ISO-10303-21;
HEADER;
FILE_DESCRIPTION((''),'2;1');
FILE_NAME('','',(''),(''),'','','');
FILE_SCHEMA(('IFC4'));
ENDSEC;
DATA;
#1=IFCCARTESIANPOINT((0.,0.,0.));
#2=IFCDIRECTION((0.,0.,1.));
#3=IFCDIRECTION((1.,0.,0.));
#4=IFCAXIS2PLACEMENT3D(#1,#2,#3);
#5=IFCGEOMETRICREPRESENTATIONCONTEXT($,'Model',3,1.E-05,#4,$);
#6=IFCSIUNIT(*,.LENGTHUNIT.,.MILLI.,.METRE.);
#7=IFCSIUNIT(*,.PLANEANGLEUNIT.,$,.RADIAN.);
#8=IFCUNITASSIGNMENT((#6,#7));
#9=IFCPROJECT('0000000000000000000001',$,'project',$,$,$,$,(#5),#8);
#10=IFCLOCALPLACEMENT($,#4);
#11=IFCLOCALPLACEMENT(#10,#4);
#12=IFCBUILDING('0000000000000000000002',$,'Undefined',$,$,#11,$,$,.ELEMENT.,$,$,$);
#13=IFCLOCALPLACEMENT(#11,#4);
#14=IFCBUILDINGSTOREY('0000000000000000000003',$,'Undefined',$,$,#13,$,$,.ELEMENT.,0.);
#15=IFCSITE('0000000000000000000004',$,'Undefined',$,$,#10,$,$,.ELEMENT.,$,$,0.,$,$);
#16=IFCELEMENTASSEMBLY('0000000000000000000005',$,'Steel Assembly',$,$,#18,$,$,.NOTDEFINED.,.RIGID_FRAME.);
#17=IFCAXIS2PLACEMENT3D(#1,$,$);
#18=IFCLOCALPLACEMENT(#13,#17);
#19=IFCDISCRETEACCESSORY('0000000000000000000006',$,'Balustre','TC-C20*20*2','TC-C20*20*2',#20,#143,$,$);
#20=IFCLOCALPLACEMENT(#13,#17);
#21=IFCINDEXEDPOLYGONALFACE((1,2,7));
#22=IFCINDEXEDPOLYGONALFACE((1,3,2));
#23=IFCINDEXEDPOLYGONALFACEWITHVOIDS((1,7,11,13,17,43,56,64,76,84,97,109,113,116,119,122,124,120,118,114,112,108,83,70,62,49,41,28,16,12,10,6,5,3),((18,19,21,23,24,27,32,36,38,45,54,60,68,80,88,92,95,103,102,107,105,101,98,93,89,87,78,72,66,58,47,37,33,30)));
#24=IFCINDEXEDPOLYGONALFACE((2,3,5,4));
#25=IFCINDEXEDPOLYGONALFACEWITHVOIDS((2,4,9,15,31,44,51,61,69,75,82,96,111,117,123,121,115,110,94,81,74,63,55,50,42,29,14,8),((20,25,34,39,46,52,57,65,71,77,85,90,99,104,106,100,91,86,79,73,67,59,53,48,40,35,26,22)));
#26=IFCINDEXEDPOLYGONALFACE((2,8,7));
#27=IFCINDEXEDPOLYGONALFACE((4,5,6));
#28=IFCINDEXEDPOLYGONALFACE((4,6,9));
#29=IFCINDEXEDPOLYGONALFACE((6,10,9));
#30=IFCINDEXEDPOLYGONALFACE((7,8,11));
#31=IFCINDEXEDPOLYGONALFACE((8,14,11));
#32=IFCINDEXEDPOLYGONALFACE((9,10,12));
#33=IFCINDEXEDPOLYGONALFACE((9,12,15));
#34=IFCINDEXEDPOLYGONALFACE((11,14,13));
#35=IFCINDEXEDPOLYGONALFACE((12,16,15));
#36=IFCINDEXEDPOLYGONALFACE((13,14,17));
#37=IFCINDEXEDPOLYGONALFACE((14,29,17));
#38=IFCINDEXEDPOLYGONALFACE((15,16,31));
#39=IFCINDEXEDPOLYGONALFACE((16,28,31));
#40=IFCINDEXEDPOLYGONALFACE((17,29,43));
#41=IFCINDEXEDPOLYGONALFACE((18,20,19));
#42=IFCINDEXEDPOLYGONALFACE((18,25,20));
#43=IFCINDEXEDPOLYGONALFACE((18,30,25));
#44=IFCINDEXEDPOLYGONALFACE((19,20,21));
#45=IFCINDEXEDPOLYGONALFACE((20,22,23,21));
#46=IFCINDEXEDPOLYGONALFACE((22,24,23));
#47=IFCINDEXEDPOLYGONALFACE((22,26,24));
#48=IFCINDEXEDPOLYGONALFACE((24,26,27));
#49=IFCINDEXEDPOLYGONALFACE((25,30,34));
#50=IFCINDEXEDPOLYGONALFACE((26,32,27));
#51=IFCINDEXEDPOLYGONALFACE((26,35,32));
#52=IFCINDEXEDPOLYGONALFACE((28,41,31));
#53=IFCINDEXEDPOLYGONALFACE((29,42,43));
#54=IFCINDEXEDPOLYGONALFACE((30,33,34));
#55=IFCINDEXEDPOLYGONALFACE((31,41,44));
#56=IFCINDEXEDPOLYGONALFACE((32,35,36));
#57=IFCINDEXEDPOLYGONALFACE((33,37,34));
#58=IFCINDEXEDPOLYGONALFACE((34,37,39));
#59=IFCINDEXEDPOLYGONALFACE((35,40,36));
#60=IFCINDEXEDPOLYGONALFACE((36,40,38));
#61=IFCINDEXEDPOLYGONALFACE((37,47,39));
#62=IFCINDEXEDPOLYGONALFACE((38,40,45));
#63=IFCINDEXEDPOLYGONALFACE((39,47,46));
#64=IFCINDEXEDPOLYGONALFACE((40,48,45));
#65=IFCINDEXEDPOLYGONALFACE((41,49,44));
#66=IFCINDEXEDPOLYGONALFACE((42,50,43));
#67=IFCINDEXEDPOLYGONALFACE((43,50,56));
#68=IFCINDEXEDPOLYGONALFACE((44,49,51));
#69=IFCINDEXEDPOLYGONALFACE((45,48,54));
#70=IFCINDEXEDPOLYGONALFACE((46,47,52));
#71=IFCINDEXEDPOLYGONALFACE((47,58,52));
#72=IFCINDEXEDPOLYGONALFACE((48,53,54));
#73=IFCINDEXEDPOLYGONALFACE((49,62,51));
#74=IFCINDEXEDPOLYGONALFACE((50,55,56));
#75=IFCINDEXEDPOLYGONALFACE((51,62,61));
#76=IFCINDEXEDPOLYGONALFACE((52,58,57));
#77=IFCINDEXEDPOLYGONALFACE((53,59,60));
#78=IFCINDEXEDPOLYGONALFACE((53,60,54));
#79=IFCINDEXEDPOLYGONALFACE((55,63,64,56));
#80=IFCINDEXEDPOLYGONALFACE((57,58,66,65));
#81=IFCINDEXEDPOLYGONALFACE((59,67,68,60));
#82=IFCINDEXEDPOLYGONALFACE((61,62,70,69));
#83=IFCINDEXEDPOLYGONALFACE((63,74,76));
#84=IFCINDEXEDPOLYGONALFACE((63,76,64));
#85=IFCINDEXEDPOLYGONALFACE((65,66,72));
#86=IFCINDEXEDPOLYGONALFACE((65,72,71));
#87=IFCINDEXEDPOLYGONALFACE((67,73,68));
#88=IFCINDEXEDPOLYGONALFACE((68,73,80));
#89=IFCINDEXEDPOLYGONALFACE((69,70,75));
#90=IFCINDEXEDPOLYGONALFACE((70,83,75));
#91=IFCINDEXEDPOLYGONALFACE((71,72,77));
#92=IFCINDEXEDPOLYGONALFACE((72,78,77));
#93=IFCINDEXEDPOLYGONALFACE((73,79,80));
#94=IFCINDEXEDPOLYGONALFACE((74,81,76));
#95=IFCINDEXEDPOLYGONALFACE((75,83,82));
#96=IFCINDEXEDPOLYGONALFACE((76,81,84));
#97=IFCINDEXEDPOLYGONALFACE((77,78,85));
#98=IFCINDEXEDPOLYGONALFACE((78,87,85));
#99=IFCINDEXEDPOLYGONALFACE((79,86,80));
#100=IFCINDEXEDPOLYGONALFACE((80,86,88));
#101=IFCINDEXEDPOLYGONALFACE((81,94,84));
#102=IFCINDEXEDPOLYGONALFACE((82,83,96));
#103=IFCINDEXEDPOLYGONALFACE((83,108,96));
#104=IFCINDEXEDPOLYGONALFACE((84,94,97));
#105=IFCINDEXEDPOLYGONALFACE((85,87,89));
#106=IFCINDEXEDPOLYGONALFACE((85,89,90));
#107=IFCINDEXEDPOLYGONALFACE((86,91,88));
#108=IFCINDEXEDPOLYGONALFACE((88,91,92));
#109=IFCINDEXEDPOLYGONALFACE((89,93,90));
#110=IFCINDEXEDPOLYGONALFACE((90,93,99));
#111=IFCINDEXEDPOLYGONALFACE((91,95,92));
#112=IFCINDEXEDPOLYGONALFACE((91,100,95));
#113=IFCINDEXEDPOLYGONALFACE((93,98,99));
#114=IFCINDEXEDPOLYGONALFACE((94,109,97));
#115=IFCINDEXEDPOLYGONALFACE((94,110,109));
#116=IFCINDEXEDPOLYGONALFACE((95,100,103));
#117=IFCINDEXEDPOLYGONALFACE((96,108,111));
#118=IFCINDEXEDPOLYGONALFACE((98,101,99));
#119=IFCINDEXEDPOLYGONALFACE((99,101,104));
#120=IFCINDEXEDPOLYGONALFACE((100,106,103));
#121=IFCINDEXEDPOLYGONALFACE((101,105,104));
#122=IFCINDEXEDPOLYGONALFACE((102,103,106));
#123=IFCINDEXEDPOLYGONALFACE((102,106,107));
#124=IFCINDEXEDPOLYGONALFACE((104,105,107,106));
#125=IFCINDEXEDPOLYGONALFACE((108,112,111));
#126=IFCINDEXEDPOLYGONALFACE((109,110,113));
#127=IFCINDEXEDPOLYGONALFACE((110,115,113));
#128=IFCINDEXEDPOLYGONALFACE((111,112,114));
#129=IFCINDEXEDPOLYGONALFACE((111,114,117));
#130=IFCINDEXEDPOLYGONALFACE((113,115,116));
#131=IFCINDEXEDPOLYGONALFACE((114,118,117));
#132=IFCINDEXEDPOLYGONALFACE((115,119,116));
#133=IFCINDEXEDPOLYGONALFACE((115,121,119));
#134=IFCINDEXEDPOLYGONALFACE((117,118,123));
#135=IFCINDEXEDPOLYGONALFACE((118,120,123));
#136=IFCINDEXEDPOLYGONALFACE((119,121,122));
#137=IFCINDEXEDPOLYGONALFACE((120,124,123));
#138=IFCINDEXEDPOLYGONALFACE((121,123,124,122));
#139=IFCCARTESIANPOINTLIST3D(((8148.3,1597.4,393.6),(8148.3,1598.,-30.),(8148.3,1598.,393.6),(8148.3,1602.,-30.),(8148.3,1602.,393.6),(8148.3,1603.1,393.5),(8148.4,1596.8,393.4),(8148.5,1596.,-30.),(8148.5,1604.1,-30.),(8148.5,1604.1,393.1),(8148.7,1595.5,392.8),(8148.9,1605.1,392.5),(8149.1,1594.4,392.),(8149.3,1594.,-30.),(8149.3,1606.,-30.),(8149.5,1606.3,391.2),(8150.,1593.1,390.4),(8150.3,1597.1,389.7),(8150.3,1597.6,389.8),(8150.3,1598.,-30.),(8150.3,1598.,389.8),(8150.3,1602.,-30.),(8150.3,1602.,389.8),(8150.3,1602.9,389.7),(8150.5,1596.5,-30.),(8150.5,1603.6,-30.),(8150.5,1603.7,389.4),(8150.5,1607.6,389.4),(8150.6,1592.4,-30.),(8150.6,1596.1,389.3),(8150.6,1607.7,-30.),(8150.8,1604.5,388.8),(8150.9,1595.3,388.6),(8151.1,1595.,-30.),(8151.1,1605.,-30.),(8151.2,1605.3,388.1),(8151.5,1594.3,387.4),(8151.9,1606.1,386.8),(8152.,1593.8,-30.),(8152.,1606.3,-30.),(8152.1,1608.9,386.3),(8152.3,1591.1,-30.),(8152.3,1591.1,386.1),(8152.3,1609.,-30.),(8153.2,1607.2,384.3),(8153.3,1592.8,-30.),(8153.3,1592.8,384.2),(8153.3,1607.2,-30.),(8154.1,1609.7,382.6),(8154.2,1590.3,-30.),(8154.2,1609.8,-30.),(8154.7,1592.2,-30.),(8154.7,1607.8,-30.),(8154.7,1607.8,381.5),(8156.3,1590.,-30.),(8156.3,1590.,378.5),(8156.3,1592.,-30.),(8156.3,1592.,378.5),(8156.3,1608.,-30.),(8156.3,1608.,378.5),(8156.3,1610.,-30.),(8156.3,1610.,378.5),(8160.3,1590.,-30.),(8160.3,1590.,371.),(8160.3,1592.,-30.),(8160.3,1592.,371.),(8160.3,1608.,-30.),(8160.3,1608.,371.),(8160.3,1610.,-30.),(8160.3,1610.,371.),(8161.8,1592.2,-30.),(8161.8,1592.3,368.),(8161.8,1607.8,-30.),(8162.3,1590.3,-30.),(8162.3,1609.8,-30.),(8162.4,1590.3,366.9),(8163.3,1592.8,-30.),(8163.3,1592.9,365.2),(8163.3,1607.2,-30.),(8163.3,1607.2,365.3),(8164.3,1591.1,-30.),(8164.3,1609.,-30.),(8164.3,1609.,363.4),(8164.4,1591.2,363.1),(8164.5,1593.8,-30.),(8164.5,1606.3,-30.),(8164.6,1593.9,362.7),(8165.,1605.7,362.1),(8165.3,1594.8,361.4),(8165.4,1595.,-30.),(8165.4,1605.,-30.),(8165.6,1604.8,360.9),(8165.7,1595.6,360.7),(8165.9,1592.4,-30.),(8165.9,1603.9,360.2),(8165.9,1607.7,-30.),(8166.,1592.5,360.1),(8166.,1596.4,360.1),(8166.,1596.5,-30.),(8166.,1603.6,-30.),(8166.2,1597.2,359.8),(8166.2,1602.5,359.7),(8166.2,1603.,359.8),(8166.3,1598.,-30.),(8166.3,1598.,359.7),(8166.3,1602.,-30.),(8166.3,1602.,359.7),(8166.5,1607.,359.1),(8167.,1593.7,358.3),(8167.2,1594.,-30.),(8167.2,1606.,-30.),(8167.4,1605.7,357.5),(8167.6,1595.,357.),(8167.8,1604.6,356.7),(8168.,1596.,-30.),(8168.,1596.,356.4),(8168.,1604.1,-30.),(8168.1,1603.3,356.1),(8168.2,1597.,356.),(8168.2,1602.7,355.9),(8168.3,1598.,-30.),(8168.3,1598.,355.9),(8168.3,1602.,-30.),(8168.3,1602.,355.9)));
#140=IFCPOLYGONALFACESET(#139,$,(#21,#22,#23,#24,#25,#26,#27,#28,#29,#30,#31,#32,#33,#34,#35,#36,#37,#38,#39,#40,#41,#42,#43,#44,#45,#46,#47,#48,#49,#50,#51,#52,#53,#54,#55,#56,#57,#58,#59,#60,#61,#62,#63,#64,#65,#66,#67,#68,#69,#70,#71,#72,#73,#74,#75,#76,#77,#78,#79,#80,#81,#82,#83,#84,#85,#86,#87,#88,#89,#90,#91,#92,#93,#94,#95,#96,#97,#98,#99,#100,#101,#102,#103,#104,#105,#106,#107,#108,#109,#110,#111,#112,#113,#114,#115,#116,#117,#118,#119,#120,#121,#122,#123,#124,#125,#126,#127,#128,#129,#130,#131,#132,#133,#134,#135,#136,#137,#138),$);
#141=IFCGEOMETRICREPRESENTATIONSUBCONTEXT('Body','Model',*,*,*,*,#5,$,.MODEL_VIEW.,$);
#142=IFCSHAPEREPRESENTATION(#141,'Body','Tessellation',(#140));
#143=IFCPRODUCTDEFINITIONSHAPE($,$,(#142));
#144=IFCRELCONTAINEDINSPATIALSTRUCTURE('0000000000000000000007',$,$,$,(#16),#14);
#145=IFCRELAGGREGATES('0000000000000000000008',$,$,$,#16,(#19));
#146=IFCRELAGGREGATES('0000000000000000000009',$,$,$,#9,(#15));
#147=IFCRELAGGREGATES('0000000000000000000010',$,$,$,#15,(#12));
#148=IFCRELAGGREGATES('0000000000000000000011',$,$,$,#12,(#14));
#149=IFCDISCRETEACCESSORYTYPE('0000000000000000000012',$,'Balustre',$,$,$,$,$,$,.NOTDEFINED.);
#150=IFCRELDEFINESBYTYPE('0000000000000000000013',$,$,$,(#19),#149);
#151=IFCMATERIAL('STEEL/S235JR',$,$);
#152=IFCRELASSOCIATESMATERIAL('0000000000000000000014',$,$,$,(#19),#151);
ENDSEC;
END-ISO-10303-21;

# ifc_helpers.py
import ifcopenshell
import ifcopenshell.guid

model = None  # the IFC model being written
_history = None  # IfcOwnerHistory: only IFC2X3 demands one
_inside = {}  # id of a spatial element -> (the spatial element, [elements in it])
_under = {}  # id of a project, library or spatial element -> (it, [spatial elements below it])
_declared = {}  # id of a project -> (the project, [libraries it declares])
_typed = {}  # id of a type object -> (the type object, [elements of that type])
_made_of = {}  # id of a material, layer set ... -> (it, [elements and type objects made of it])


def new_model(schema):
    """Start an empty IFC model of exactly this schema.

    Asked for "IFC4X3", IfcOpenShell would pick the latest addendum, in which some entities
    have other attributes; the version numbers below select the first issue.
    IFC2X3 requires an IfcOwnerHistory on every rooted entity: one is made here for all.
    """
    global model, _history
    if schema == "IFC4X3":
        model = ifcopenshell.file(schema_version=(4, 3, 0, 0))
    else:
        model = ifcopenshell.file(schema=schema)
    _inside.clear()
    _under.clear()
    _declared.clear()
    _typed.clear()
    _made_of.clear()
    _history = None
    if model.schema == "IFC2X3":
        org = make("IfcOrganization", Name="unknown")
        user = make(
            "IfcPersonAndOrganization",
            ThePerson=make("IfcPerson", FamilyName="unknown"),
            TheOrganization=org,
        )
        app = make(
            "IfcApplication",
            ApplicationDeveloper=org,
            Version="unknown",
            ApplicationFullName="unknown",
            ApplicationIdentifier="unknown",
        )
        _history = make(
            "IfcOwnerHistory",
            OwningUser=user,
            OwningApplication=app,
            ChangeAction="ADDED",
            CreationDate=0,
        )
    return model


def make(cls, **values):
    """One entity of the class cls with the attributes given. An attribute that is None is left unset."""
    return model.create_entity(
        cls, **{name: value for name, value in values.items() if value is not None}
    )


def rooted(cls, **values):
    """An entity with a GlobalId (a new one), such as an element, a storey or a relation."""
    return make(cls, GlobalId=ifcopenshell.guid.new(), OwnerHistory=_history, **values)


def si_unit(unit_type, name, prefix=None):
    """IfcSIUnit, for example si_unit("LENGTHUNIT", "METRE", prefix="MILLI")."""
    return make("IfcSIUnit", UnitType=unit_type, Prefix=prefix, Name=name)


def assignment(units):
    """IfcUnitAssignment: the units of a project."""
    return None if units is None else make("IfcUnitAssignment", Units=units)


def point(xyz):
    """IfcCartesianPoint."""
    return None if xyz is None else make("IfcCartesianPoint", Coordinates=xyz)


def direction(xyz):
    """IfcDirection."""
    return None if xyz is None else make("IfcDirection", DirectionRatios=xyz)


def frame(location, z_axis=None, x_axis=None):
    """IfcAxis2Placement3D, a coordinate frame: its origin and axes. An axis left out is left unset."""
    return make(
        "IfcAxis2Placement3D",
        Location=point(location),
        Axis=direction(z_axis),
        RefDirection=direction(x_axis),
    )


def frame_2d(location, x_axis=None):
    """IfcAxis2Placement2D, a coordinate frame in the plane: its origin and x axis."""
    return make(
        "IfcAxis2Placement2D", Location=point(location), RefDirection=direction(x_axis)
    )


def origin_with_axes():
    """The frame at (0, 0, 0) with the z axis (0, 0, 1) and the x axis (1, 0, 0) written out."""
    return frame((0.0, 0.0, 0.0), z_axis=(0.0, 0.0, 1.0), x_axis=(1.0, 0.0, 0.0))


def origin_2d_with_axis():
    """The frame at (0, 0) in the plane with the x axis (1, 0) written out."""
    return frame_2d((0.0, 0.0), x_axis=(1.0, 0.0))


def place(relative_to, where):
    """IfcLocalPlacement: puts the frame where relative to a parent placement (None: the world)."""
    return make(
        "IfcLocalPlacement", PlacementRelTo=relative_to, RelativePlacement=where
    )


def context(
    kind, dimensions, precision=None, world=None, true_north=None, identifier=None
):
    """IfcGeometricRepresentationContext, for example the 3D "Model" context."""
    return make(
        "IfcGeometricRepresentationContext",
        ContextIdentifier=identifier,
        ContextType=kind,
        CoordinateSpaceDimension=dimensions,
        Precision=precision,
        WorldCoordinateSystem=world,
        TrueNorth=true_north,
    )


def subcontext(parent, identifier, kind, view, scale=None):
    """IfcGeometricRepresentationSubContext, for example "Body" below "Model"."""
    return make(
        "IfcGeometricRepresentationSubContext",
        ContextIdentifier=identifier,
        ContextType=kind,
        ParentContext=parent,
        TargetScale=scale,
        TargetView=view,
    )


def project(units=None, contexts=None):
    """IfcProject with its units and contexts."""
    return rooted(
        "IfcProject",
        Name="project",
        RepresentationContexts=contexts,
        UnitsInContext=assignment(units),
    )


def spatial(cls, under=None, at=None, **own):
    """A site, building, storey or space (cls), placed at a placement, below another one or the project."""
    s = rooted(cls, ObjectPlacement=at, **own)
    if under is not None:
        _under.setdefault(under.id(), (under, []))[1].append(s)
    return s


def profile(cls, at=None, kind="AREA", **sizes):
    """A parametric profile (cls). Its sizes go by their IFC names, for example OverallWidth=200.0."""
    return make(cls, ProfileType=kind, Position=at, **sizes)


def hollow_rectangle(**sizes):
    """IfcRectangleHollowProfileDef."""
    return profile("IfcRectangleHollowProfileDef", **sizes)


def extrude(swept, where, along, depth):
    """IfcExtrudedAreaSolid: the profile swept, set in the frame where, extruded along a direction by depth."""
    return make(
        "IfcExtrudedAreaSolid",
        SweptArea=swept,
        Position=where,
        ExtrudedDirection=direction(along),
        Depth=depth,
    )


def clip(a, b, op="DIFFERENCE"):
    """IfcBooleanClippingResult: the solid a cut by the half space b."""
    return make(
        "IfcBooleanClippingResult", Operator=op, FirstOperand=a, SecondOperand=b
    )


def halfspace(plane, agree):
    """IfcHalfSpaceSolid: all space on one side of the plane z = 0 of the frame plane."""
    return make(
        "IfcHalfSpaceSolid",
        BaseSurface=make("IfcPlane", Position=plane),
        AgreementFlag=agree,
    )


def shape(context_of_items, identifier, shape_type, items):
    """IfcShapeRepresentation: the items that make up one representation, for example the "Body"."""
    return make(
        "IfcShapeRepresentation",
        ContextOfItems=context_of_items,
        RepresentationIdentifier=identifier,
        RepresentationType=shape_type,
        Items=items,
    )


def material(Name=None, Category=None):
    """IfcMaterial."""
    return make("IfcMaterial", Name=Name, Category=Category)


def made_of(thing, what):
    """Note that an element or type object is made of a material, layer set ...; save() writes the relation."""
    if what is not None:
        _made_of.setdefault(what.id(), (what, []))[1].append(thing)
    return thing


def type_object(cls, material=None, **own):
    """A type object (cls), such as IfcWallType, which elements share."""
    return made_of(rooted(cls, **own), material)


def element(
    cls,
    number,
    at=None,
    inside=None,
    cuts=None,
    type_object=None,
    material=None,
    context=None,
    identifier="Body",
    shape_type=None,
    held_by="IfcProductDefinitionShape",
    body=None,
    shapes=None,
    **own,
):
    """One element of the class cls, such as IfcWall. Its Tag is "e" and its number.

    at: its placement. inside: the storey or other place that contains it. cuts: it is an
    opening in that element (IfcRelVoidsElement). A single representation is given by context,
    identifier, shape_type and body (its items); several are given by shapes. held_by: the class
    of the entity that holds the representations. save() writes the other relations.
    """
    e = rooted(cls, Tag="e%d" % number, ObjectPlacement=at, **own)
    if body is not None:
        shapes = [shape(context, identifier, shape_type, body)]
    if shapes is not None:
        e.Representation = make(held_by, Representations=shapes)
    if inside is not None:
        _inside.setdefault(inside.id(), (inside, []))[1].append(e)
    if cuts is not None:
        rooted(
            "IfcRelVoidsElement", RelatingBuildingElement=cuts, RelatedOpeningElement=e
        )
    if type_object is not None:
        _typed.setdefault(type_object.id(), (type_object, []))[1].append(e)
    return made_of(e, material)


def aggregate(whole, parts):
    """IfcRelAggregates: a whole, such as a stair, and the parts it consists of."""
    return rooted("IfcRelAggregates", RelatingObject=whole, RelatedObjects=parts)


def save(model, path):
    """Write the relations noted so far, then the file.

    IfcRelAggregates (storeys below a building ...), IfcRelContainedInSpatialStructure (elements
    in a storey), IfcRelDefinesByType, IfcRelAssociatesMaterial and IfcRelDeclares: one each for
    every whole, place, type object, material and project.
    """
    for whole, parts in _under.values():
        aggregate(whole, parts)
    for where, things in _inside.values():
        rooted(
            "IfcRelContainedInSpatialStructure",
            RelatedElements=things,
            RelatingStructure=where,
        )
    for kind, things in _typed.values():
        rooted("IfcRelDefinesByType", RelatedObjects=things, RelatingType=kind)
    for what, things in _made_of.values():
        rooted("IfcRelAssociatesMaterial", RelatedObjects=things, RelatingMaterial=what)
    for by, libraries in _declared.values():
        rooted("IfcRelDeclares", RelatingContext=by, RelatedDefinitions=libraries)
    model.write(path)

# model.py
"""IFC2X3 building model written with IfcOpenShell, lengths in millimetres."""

from ifc_helpers import new_model, si_unit, frame, origin_with_axes, origin_2d_with_axis, place, context, subcontext, project, spatial, hollow_rectangle, extrude, clip, halfspace, material, type_object, element, aggregate, save


model = new_model("IFC2X3")

# Units and contexts
model_context = context("Model", 3, precision=1e-05, world=origin_with_axes())
body_context = subcontext(model_context, "Body", "Model", "MODEL_VIEW")
ifc_project = project(units=[si_unit("LENGTHUNIT", "METRE", prefix="MILLI"), si_unit("PLANEANGLEUNIT", "RADIAN")], contexts=[model_context])

# Site, building, storey
site_placement = place(None, origin_with_axes())
site = spatial("IfcSite", under=ifc_project, at=site_placement, Name="Undefined", CompositionType="ELEMENT", RefElevation=0.0)
building_placement = place(site_placement, origin_with_axes())
building = spatial("IfcBuilding", under=site, at=building_placement, Name="Undefined", CompositionType="ELEMENT")
storey_placement = place(building_placement, origin_with_axes())
storey = spatial("IfcBuildingStorey", under=building, at=storey_placement, Name="Undefined", CompositionType="ELEMENT", Elevation=0.0)

# Shared definitions
ifc_material = material(Name="STEEL/S235JR")

# Element assembly, discrete accessory
assembly_1_placement = place(storey_placement, origin_with_axes())
assembly_1 = element("IfcElementAssembly", 1, at=assembly_1_placement, inside=storey, Name="Steel Assembly", AssemblyPlace="NOTDEFINED", PredefinedType="RIGID_FRAME")
discrete_accessory_type_1 = type_object("IfcDiscreteAccessoryType", Name="Balustre")
discrete_accessory_1_placement = place(assembly_1_placement, frame((8158.3, 1600.0, -30.0), z_axis=(0.0, 0.0, 1.0), x_axis=(1.0, 0.0, 0.0)))
discrete_accessory_1 = element("IfcDiscreteAccessory", 2, at=discrete_accessory_1_placement, type_object=discrete_accessory_type_1, material=ifc_material, Name="Balustre", Description="TC-C20*20*2", ObjectType="TC-C20*20*2", context=body_context, shape_type="Clipping", body=[
    clip(extrude(hollow_rectangle(XDim=20.0, YDim=20.0, WallThickness=2.0, InnerFilletRadius=6.0, OuterFilletRadius=8.0, at=origin_2d_with_axis()), frame((0.0, 0.0, 423.8), z_axis=(0.0, 0.0, -1.0), x_axis=(-1.0, -0.000011, 0.0)), (0.0, 0.0, 1.0), 423.8), halfspace(frame((63.3, 0.0, 285.4), z_axis=(-0.883506, -0.000005, -0.46842), x_axis=(-0.000005, 1.0, 0.0)), True)),
])

aggregate(assembly_1, [discrete_accessory_1])

save(model, "model.ifc")
